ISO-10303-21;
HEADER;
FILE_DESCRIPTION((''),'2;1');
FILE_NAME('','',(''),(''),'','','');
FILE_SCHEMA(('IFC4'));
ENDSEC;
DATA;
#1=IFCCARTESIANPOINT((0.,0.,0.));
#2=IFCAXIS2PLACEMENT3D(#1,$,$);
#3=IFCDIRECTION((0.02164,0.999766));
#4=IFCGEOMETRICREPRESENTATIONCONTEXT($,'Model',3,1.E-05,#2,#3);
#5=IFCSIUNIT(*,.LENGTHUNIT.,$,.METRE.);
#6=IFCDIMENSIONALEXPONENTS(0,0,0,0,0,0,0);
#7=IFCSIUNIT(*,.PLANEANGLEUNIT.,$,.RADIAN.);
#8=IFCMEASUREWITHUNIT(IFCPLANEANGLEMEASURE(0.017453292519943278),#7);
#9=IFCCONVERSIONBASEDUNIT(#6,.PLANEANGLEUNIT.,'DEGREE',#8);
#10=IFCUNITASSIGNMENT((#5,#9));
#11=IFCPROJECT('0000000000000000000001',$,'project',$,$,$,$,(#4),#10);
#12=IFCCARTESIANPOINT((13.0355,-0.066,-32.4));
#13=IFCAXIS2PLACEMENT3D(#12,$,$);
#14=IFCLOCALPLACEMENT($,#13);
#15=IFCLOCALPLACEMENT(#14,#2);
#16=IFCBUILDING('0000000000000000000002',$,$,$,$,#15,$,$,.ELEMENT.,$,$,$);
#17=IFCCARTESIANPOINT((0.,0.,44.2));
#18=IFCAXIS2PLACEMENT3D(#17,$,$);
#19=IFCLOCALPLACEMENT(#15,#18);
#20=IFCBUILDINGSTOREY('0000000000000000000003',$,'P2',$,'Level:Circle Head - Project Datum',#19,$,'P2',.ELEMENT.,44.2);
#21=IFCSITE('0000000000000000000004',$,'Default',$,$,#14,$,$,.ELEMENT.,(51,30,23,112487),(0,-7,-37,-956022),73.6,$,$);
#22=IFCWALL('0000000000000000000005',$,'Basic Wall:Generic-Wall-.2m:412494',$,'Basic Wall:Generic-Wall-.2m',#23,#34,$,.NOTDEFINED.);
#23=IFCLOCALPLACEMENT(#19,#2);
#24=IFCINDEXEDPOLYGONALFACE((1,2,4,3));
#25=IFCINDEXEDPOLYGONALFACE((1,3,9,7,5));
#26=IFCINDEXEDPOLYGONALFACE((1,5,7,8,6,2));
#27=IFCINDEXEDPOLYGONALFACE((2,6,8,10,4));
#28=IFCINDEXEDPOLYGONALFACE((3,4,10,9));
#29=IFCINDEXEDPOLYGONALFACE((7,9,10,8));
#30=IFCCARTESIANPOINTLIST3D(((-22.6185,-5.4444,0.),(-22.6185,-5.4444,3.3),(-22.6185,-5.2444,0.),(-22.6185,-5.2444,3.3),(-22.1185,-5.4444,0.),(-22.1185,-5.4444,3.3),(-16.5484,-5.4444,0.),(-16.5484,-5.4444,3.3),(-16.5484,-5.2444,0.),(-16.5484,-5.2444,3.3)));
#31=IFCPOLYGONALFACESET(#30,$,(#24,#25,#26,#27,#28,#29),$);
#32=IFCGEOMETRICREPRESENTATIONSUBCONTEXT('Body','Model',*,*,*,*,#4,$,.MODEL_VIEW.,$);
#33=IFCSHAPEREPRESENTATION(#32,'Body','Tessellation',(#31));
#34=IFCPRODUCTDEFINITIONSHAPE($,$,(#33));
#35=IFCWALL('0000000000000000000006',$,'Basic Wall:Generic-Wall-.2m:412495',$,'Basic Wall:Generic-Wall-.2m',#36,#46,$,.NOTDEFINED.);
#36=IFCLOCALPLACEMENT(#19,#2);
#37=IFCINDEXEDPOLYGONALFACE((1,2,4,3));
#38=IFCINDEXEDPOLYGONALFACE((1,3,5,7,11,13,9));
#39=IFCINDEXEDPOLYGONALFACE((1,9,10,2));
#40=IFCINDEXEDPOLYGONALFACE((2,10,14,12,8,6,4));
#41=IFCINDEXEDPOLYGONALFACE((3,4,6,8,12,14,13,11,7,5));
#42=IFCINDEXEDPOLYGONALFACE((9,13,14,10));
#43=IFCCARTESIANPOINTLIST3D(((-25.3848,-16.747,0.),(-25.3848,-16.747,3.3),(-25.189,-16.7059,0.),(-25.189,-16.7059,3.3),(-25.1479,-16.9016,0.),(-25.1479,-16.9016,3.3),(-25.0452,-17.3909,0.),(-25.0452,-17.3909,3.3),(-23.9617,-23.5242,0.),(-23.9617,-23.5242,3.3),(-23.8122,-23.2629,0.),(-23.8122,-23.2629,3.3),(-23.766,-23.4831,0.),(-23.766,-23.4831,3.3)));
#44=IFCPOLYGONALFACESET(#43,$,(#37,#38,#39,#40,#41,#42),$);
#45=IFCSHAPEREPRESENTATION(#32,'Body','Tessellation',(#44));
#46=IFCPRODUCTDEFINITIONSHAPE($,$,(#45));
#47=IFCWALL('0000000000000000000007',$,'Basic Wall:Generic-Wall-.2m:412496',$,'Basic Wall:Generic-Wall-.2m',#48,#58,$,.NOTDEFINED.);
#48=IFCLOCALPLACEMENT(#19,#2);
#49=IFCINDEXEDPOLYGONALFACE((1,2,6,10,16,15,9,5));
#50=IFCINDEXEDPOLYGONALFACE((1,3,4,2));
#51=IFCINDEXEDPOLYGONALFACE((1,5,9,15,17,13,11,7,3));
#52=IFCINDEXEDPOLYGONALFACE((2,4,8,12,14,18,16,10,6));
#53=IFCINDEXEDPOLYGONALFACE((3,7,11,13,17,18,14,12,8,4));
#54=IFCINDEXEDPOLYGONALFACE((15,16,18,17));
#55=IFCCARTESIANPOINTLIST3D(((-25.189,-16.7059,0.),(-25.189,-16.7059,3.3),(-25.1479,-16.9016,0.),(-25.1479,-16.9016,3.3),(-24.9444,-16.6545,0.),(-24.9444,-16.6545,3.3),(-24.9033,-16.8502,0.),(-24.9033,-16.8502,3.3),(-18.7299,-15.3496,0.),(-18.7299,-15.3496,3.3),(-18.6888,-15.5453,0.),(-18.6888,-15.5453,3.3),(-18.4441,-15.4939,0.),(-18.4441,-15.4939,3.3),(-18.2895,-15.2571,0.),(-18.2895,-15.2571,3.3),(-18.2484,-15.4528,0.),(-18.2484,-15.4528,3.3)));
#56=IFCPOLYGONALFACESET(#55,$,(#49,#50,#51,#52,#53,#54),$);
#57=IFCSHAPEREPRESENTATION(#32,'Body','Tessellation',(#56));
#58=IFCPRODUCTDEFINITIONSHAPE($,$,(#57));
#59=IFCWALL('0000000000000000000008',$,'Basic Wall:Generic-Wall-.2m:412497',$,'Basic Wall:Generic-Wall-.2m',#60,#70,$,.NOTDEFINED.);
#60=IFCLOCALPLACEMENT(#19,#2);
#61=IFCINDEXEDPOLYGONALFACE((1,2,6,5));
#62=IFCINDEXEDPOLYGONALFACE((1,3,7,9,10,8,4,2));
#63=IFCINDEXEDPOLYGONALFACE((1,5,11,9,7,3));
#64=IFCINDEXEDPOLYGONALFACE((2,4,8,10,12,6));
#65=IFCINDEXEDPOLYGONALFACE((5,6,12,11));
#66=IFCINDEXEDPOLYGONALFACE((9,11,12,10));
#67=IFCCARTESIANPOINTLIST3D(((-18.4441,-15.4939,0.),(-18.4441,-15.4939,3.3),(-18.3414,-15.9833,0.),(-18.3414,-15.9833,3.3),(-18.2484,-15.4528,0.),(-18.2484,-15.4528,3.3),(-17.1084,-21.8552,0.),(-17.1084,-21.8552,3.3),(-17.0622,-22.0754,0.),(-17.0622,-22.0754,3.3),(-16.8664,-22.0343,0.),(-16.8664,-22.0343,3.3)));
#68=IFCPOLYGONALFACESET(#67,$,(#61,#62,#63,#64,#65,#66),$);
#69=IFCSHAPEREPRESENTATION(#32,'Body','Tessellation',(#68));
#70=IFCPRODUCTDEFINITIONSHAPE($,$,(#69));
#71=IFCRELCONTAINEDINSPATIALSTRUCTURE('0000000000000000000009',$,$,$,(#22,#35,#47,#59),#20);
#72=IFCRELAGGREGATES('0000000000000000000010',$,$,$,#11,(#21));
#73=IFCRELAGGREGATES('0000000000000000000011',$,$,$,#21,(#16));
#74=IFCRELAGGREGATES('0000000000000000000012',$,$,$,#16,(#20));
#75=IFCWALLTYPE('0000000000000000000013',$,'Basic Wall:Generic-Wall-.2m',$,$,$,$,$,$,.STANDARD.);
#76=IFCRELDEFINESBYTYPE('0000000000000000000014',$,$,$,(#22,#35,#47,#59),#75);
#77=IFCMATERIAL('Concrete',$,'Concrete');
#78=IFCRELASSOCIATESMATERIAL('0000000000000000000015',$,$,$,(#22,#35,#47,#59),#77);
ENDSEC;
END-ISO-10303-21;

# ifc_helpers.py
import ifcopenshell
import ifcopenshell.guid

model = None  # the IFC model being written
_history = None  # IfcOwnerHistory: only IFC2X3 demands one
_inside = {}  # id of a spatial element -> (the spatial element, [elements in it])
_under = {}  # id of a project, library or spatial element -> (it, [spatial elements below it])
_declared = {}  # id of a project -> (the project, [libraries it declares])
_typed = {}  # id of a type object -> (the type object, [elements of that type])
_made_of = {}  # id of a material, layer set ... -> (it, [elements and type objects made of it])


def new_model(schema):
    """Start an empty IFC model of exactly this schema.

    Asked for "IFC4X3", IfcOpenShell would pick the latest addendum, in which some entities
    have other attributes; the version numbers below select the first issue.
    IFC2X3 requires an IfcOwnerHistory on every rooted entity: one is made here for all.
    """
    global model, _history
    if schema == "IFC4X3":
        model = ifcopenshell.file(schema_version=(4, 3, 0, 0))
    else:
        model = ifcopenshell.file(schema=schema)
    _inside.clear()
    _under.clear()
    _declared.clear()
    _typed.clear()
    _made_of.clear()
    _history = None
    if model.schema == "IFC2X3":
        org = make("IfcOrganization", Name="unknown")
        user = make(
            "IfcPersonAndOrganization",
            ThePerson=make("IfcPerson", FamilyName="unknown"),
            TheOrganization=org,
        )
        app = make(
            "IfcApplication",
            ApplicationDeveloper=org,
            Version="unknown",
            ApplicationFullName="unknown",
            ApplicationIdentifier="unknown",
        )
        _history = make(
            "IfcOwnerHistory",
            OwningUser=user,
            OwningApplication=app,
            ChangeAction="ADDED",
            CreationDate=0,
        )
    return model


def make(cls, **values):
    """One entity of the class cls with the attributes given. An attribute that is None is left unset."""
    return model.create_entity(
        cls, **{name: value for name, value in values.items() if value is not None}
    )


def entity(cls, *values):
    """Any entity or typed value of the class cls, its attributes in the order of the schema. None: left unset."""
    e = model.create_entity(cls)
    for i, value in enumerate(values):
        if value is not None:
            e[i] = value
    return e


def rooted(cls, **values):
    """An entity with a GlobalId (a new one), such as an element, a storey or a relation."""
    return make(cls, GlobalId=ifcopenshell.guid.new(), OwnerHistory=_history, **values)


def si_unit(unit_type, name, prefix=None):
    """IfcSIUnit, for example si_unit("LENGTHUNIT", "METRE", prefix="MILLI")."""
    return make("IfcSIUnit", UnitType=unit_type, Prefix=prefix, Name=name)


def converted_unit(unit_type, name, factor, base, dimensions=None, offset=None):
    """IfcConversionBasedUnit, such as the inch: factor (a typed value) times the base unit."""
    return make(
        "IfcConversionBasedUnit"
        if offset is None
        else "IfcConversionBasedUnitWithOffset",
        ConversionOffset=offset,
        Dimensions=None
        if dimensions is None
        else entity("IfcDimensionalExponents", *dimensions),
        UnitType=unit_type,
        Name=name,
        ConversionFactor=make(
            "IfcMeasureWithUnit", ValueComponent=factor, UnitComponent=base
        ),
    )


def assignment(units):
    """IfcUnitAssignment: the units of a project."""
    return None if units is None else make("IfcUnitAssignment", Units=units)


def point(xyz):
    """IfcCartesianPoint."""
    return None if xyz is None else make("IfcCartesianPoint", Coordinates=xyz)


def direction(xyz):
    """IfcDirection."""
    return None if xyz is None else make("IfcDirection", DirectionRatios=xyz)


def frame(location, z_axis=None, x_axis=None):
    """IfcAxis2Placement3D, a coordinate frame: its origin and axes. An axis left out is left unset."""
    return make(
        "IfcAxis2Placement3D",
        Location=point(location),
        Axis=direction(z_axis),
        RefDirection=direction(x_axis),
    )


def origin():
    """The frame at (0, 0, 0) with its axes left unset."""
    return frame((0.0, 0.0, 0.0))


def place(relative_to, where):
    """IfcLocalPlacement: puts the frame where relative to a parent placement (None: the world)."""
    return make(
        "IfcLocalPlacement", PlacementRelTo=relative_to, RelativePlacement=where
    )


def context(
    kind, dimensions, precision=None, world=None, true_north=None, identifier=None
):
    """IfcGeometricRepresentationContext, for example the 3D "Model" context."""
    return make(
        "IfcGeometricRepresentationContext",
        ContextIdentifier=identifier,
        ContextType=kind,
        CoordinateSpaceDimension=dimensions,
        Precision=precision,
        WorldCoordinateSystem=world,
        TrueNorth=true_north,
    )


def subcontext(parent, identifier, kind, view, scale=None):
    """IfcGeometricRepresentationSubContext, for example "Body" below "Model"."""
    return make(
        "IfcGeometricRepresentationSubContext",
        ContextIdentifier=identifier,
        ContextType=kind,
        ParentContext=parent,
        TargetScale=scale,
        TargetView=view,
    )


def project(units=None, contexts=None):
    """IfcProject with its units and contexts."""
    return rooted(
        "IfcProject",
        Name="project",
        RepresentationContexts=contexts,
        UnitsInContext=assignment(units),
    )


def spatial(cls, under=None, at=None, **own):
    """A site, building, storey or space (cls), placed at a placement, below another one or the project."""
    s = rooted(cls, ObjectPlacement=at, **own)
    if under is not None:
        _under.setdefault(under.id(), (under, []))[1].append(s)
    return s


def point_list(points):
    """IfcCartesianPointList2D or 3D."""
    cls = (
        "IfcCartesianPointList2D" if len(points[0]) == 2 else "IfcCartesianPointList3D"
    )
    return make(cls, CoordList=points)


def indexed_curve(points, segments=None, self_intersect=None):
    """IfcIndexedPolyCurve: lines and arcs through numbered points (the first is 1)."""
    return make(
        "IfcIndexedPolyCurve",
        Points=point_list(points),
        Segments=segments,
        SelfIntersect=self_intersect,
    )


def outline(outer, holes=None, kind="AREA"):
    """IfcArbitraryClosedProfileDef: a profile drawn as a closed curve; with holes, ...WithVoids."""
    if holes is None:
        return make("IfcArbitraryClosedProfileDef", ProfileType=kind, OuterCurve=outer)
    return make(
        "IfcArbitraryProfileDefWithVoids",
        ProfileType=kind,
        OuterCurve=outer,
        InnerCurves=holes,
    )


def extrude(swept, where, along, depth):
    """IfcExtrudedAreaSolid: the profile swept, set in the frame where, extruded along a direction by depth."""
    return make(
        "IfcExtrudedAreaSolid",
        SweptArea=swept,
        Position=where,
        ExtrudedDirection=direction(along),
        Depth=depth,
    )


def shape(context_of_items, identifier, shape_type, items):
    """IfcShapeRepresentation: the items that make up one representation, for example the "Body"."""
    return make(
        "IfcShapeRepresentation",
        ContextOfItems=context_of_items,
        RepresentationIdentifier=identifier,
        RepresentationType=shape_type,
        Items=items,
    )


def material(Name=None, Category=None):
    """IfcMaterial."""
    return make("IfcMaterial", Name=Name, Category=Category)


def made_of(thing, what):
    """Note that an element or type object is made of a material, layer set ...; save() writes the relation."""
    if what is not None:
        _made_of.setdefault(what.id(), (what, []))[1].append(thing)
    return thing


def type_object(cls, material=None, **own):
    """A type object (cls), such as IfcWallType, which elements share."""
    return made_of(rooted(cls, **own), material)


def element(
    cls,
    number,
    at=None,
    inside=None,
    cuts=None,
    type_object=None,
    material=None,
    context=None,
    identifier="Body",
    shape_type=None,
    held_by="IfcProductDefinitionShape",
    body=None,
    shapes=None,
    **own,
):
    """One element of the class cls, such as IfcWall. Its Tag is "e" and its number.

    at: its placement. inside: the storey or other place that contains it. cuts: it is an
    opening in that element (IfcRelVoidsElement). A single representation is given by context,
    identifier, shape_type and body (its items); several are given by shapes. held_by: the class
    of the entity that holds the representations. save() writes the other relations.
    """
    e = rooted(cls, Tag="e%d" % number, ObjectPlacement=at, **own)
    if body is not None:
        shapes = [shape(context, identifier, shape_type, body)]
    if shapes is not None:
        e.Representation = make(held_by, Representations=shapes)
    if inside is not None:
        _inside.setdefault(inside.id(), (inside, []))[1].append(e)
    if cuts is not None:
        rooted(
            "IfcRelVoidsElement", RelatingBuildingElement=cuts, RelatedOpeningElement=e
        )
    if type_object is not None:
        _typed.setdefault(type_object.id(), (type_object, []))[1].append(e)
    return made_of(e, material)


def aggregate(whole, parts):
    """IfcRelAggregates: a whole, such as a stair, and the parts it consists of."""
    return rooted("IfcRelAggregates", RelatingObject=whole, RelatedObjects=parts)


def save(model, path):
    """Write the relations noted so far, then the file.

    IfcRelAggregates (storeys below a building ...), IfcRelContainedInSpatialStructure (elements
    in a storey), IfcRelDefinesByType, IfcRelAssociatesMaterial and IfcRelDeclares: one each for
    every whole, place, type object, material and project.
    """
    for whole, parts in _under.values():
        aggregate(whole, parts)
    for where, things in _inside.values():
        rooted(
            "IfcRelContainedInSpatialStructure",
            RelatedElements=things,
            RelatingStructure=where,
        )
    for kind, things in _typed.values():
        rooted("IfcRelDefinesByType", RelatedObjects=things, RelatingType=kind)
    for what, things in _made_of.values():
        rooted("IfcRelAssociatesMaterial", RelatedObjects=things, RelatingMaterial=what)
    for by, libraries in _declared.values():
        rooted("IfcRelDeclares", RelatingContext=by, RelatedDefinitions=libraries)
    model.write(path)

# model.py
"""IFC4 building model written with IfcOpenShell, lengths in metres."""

from ifc_helpers import new_model, entity, si_unit, converted_unit, direction, frame, origin, place, context, subcontext, project, spatial, indexed_curve, outline, extrude, material, type_object, element, save


model = new_model("IFC4")

# Units and contexts
model_context = context("Model", 3, precision=1e-05, world=origin(), true_north=direction((0.02164, 0.999766)))
body_context = subcontext(model_context, "Body", "Model", "MODEL_VIEW")
ifc_project = project(units=[si_unit("LENGTHUNIT", "METRE"), converted_unit("PLANEANGLEUNIT", "DEGREE", entity("IfcPlaneAngleMeasure", 0.017453292519943278), si_unit("PLANEANGLEUNIT", "RADIAN"), dimensions=[0, 0, 0, 0, 0, 0, 0])], contexts=[model_context])

# Site, building, storey
site_placement = place(None, frame((13.0355, -0.066, -32.4)))
site = spatial("IfcSite", under=ifc_project, at=site_placement, Name="Default", CompositionType="ELEMENT", RefLatitude=(51, 30, 23, 112487), RefLongitude=(0, -7, -37, -956022), RefElevation=73.6)
building_placement = place(site_placement, origin())
building = spatial("IfcBuilding", under=site, at=building_placement, CompositionType="ELEMENT")
storey_placement = place(building_placement, frame((0.0, 0.0, 44.2)))
storey = spatial("IfcBuildingStorey", under=building, at=storey_placement, Name="P2", ObjectType="Level:Circle Head - Project Datum", LongName="P2", CompositionType="ELEMENT", Elevation=44.2)

# Shared definitions
ifc_material = material(Name="Concrete", Category="Concrete")

# Walls
wall_type_1 = type_object("IfcWallType", Name="Basic Wall:Generic-Wall-.2m", PredefinedType="STANDARD")
wall_1_placement = place(storey_placement, frame((-22.6185, -5.3444, 0.0)))
element("IfcWall", 1, at=wall_1_placement, inside=storey, type_object=wall_type_1, material=ifc_material, Name="Basic Wall:Generic-Wall-.2m:412494", ObjectType="Basic Wall:Generic-Wall-.2m", PredefinedType="NOTDEFINED", context=body_context, shape_type="SweptSolid", body=[
    extrude(outline(indexed_curve([(6.0701, -0.1), (6.0701, 0.1), (0.0, 0.1), (0.0, -0.1), (0.5, -0.1), (6.0701, -0.1)], self_intersect=False)), origin(), (0.0, 0.0, 1.0), 3.3),
])
wall_2_placement = place(storey_placement, frame((-23.8638, -23.5036, 0.0), z_axis=(0.0, 0.0, 1.0), x_axis=(-0.2055, 0.978657, 0.0)))
element("IfcWall", 2, at=wall_2_placement, inside=storey, type_object=wall_type_1, material=ifc_material, Name="Basic Wall:Generic-Wall-.2m:412495", ObjectType="Basic Wall:Generic-Wall-.2m", PredefinedType="NOTDEFINED", context=body_context, shape_type="SweptSolid", body=[
    extrude(outline(indexed_curve([(6.925, -0.1), (6.925, 0.1), (0.0, 0.1), (0.0, -0.1), (0.225, -0.1), (6.225, -0.1), (6.725, -0.1), (6.925, -0.1)], self_intersect=False)), origin(), (0.0, 0.0, 1.0), 3.3),
])
wall_3_placement = place(storey_placement, frame((-25.1685, -16.8038, 0.0), z_axis=(0.0, 0.0, 1.0), x_axis=(0.978657, 0.2055, 0.0)))
element("IfcWall", 3, at=wall_3_placement, inside=storey, type_object=wall_type_1, material=ifc_material, Name="Basic Wall:Generic-Wall-.2m:412496", ObjectType="Basic Wall:Generic-Wall-.2m", PredefinedType="NOTDEFINED", context=body_context, shape_type="SweptSolid", body=[
    extrude(outline(indexed_curve([(7.05, -0.1), (7.05, 0.1), (6.6, 0.1), (0.25, 0.1), (0.0, 0.1), (0.0, -0.1), (0.25, -0.1), (6.6, -0.1), (6.85, -0.1), (7.05, -0.1)], self_intersect=False)), origin(), (0.0, 0.0, 1.0), 3.3),
])
wall_4_placement = place(storey_placement, frame((-18.3463, -15.4734, 0.0), z_axis=(0.0, 0.0, 1.0), x_axis=(0.2055, -0.978657, 0.0)))
element("IfcWall", 4, at=wall_4_placement, inside=storey, type_object=wall_type_1, material=ifc_material, Name="Basic Wall:Generic-Wall-.2m:412497", ObjectType="Basic Wall:Generic-Wall-.2m", PredefinedType="NOTDEFINED", context=body_context, shape_type="SweptSolid", body=[
    extrude(outline(indexed_curve([(6.725, -0.1), (6.725, 0.1), (0.0, 0.1), (0.0, -0.1), (0.5, -0.1), (6.5, -0.1), (6.725, -0.1)], self_intersect=False)), origin(), (0.0, 0.0, 1.0), 3.3),
])

save(model, "model.ifc")
